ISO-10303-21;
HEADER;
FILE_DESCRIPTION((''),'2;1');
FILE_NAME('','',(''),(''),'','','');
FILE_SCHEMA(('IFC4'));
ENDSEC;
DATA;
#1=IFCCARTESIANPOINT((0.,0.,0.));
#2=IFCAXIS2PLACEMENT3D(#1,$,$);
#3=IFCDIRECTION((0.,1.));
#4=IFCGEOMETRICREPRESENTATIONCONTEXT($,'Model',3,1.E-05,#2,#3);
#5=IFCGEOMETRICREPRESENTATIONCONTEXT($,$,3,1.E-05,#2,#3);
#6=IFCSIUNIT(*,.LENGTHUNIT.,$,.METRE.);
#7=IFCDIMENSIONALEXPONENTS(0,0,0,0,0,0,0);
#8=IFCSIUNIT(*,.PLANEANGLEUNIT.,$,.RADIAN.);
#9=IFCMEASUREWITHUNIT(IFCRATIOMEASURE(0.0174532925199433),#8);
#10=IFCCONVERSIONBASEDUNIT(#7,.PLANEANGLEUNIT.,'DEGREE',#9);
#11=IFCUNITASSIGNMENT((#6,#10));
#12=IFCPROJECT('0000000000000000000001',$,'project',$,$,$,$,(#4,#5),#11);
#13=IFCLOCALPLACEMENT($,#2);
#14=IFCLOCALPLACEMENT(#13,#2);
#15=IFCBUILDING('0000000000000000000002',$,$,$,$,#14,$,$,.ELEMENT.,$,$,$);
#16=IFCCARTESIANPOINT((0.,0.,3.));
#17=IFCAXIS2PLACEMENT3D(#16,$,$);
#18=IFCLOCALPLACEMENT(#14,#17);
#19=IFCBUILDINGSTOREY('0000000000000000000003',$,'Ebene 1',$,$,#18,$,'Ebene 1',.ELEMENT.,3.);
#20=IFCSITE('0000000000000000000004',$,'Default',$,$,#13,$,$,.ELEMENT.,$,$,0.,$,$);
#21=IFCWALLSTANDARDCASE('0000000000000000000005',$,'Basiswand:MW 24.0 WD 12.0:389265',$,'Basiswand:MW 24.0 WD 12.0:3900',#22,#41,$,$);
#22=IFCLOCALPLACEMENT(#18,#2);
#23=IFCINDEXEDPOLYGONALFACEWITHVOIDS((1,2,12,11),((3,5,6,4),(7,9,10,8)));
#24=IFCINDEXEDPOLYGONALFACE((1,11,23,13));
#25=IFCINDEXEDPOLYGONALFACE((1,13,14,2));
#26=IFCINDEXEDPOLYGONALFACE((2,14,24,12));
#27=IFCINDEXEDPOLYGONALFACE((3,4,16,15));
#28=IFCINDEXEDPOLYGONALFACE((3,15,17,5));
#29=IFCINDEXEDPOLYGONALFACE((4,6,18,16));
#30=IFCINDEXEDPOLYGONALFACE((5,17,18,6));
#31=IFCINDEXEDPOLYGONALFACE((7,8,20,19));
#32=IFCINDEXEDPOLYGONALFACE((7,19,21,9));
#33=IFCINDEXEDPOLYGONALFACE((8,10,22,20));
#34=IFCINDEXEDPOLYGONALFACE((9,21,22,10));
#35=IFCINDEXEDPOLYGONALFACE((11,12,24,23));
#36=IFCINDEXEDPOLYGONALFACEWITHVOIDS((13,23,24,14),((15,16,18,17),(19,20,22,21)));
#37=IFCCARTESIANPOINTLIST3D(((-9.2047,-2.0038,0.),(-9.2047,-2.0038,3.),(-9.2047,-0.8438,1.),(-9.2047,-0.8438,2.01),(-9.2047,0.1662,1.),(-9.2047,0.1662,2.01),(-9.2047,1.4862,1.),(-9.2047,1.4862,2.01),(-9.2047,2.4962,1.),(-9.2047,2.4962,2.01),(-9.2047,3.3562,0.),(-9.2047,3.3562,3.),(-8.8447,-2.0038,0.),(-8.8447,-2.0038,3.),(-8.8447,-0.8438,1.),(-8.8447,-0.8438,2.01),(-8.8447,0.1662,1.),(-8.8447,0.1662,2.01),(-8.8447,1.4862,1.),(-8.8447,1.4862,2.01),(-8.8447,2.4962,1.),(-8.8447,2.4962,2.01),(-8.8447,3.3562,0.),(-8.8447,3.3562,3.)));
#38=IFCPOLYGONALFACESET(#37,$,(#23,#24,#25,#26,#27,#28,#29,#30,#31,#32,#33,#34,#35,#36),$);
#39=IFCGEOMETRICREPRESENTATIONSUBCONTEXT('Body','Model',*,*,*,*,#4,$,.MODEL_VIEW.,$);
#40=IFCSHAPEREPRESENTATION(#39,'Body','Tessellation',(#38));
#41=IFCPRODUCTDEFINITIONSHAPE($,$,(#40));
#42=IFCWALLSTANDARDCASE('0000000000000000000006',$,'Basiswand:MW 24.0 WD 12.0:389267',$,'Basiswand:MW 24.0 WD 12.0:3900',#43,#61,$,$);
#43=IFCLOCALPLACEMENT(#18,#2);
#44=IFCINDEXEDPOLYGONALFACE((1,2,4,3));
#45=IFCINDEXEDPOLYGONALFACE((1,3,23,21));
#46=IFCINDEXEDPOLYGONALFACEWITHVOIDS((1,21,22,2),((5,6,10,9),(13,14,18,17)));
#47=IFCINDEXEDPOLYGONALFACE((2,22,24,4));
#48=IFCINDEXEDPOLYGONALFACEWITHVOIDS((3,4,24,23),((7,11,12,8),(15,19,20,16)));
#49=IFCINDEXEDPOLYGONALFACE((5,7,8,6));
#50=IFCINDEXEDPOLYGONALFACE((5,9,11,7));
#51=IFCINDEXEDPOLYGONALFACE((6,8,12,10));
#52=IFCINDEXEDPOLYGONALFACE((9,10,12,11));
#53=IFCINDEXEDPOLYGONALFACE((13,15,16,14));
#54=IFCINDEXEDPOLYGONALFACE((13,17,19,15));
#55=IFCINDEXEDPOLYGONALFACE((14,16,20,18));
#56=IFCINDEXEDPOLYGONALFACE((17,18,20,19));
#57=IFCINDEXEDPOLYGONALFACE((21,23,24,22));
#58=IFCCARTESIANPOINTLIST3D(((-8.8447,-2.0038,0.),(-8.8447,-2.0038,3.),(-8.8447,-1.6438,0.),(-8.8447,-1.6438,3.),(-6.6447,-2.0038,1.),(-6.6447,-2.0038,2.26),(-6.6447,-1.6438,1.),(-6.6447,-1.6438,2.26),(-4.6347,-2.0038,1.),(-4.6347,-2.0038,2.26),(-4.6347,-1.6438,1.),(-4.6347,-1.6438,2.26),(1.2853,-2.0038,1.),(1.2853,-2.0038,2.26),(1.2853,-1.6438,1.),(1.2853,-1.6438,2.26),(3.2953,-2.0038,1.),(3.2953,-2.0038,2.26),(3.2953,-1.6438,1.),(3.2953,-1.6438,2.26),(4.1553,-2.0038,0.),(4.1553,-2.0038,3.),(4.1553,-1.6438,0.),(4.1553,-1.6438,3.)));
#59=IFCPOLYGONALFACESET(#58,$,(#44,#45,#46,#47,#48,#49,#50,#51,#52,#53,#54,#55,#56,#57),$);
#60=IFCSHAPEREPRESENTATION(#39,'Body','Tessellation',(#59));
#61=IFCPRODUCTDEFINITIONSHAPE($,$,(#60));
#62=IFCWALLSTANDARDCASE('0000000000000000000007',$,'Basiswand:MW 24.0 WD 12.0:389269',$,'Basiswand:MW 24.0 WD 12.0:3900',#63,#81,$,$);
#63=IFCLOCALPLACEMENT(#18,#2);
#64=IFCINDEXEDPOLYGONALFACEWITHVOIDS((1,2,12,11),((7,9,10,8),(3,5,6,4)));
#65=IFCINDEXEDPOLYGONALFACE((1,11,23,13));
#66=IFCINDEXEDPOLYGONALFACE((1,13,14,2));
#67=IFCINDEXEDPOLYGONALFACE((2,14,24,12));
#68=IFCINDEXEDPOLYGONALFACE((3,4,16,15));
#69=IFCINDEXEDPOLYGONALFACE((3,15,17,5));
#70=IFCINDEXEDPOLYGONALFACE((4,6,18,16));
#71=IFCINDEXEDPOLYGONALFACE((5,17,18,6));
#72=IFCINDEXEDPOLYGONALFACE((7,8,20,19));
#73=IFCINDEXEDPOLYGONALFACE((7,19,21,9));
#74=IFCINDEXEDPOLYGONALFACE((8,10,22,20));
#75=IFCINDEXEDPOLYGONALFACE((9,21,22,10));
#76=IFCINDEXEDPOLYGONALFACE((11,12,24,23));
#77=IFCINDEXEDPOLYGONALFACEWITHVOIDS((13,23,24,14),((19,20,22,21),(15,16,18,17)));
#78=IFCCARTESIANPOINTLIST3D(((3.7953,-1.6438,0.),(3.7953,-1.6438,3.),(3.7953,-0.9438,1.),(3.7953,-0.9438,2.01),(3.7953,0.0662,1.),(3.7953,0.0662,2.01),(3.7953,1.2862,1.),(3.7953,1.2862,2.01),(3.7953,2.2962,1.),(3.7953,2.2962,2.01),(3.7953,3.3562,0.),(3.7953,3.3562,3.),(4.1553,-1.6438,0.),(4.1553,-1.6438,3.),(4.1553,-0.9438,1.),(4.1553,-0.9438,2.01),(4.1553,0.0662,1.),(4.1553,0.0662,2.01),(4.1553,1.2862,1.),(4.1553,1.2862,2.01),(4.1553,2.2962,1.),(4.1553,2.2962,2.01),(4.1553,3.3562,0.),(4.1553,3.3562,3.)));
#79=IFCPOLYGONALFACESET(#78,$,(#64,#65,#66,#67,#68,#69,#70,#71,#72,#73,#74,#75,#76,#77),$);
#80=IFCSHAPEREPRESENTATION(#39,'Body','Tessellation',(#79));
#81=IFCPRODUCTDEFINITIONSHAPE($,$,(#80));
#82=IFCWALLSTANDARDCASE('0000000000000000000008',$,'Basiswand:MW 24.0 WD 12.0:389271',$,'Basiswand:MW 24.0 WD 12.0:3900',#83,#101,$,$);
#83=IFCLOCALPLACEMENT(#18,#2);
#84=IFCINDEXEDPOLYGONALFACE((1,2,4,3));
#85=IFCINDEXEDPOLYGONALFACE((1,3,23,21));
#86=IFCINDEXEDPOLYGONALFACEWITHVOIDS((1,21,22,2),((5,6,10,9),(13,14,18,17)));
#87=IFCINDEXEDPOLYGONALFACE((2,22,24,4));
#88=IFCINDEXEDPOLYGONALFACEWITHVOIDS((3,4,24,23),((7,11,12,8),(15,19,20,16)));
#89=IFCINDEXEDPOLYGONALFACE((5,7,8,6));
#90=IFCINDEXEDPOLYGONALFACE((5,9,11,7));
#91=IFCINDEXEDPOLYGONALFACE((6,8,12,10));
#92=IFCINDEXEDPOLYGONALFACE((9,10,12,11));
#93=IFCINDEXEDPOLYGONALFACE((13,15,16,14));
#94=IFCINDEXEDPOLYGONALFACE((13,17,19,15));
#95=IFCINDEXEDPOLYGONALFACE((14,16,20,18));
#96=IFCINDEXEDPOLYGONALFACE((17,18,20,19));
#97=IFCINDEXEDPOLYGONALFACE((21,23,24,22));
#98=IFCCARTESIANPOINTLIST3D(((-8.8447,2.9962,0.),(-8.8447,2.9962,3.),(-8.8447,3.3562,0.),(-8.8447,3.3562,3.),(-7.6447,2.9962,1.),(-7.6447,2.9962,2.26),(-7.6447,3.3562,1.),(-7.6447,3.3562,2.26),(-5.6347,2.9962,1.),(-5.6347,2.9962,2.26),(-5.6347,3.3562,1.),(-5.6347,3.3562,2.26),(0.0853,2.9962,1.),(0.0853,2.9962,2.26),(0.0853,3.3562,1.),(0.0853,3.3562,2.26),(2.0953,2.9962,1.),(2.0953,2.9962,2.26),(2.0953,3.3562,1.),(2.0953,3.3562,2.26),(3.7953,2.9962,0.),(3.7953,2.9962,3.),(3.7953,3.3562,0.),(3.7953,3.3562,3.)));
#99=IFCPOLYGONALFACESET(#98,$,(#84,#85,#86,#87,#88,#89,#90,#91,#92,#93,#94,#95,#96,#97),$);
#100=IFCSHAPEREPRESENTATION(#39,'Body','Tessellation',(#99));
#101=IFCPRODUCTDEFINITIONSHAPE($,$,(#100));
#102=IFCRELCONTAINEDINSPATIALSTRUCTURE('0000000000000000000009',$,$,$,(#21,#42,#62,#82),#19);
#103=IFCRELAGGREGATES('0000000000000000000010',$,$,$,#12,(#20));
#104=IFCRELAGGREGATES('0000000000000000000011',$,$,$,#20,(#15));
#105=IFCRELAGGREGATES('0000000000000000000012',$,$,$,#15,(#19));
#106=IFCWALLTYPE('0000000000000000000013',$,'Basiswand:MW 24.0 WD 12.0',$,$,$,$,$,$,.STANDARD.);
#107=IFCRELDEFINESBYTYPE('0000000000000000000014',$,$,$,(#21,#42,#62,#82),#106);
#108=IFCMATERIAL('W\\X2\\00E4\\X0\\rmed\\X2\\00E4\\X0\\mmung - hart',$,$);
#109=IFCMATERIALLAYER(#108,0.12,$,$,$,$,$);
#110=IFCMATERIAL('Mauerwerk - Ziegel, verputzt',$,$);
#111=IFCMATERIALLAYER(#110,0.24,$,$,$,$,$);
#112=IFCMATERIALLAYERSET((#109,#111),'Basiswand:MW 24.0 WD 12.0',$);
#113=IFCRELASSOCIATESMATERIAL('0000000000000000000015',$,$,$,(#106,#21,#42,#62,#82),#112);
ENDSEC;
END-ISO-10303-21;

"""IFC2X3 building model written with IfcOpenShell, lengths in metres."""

from ifc_helpers import new_model, entity, si_unit, converted_unit, direction, frame, frame_2d, origin, place, context, subcontext, project, spatial, rectangle, extrude, material, layer, layer_set, layer_usage, type_object, element, save


model = new_model("IFC2X3")

# Units and contexts
model_context = context("Model", 3, precision=1e-05, world=origin(), true_north=direction((0.0, 1.0)))
context_of_model = context(None, 3, precision=1e-05, world=origin(), true_north=direction((0.0, 1.0)))
body_context = subcontext(model_context, "Body", "Model", "MODEL_VIEW")
ifc_project = project(units=[si_unit("LENGTHUNIT", "METRE"), converted_unit("PLANEANGLEUNIT", "DEGREE", entity("IfcRatioMeasure", 0.0174532925199433), si_unit("PLANEANGLEUNIT", "RADIAN"), dimensions=[0, 0, 0, 0, 0, 0, 0])], contexts=[model_context, context_of_model])

# Site, building, storey
site_placement = place(None, origin())
site = spatial("IfcSite", under=ifc_project, at=site_placement, Name="Default", CompositionType="ELEMENT", RefElevation=0.0)
building_placement = place(site_placement, origin())
building = spatial("IfcBuilding", under=site, at=building_placement, CompositionType="ELEMENT")
storey_placement = place(building_placement, frame((0.0, 0.0, 3.0)))
storey = spatial("IfcBuildingStorey", under=building, at=storey_placement, Name="Ebene 1", LongName="Ebene 1", CompositionType="ELEMENT", Elevation=3.0)

# Walls, openings
ifc_material_1 = material(Name="W\\X2\\00E4\\X0\\rmed\\X2\\00E4\\X0\\mmung - hart")
ifc_layer_1 = layer(ifc_material_1, 0.12)
ifc_material_2 = material(Name="Mauerwerk - Ziegel, verputzt")
ifc_layer_2 = layer(ifc_material_2, 0.24)
ifc_layer_set = layer_set([ifc_layer_1, ifc_layer_2], Name="Basiswand:MW 24.0 WD 12.0")
ifc_layer_usage = layer_usage(ifc_layer_set, "AXIS2", "NEGATIVE", 0.18)
wall_type = type_object("IfcWallType", Name="Basiswand:MW 24.0 WD 12.0", PredefinedType="STANDARD", material=ifc_layer_set)
wall_1_placement = place(storey_placement, frame((-9.0247, 3.3562, 0.0), z_axis=(0.0, 0.0, 1.0), x_axis=(0.0, -1.0, 0.0)))
wall_1 = element("IfcWallStandardCase", 1, at=wall_1_placement, inside=storey, type_object=wall_type, material=ifc_layer_usage, Name="Basiswand:MW 24.0 WD 12.0:389265", ObjectType="Basiswand:MW 24.0 WD 12.0:3900", context=body_context, shape_type="SweptSolid", body=[
    extrude(rectangle(XDim=5.36, YDim=0.36, at=frame_2d((2.68, 0.0), x_axis=(-1.0, 0.0))), origin(), (0.0, 0.0, 1.0), 3.0),
])
opening_1_placement = place(wall_1_placement, frame((1.87, 0.18, 1.0)))
element("IfcOpeningElement", 2, at=opening_1_placement, cuts=wall_1, ObjectType="Opening", context=body_context, shape_type="SweptSolid", body=[
    extrude(rectangle(XDim=1.01, YDim=1.01, at=frame_2d((0.505, 0.505), x_axis=(1.0, 0.0))), frame((0.0, 0.0, 0.0), z_axis=(0.0, -1.0, 0.0), x_axis=(0.0, 0.0, 1.0)), (0.0, 0.0, 1.0), 0.36),
])
opening_2_placement = place(wall_1_placement, frame((4.2, 0.18, 1.0)))
element("IfcOpeningElement", 3, at=opening_2_placement, cuts=wall_1, ObjectType="Opening", context=body_context, shape_type="SweptSolid", body=[
    extrude(rectangle(XDim=1.01, YDim=1.01, at=frame_2d((0.505, 0.505), x_axis=(1.0, 0.0))), frame((0.0, 0.0, 0.0), z_axis=(0.0, -1.0, 0.0), x_axis=(0.0, 0.0, 1.0)), (0.0, 0.0, 1.0), 0.36),
])
wall_2_placement = place(storey_placement, frame((-8.8447, -1.8238, 0.0)))
wall_2 = element("IfcWallStandardCase", 4, at=wall_2_placement, inside=storey, type_object=wall_type, material=ifc_layer_usage, Name="Basiswand:MW 24.0 WD 12.0:389267", ObjectType="Basiswand:MW 24.0 WD 12.0:3900", context=body_context, shape_type="SweptSolid", body=[
    extrude(rectangle(XDim=13.0, YDim=0.36, at=frame_2d((6.5, 0.0), x_axis=(-1.0, 0.0))), origin(), (0.0, 0.0, 1.0), 3.0),
])
opening_3_placement = place(wall_2_placement, frame((12.14, 0.18, 1.0)))
element("IfcOpeningElement", 5, at=opening_3_placement, cuts=wall_2, ObjectType="Opening", context=body_context, shape_type="SweptSolid", body=[
    extrude(rectangle(XDim=1.26, YDim=2.01, at=frame_2d((0.63, 1.005), x_axis=(1.0, 0.0))), frame((0.0, 0.0, 0.0), z_axis=(0.0, -1.0, 0.0), x_axis=(0.0, 0.0, 1.0)), (0.0, 0.0, 1.0), 0.36),
])
opening_4_placement = place(wall_2_placement, frame((4.21, 0.18, 1.0)))
element("IfcOpeningElement", 6, at=opening_4_placement, cuts=wall_2, ObjectType="Opening", context=body_context, shape_type="SweptSolid", body=[
    extrude(rectangle(XDim=1.26, YDim=2.01, at=frame_2d((0.63, 1.005), x_axis=(1.0, 0.0))), frame((0.0, 0.0, 0.0), z_axis=(0.0, -1.0, 0.0), x_axis=(0.0, 0.0, 1.0)), (0.0, 0.0, 1.0), 0.36),
])
wall_3_placement = place(storey_placement, frame((3.9753, -1.6438, 0.0), z_axis=(0.0, 0.0, 1.0), x_axis=(0.0, 1.0, 0.0)))
wall_3 = element("IfcWallStandardCase", 7, at=wall_3_placement, inside=storey, type_object=wall_type, material=ifc_layer_usage, Name="Basiswand:MW 24.0 WD 12.0:389269", ObjectType="Basiswand:MW 24.0 WD 12.0:3900", context=body_context, shape_type="SweptSolid", body=[
    extrude(rectangle(XDim=5.0, YDim=0.36, at=frame_2d((2.5, 0.0), x_axis=(-1.0, 0.0))), origin(), (0.0, 0.0, 1.0), 3.0),
])
opening_5_placement = place(wall_3_placement, frame((3.94, 0.18, 1.0)))
element("IfcOpeningElement", 8, at=opening_5_placement, cuts=wall_3, ObjectType="Opening", context=body_context, shape_type="SweptSolid", body=[
    extrude(rectangle(XDim=1.01, YDim=1.01, at=frame_2d((0.505, 0.505), x_axis=(1.0, 0.0))), frame((0.0, 0.0, 0.0), z_axis=(0.0, -1.0, 0.0), x_axis=(0.0, 0.0, 1.0)), (0.0, 0.0, 1.0), 0.36),
])
opening_6_placement = place(wall_3_placement, frame((1.71, 0.18, 1.0)))
element("IfcOpeningElement", 9, at=opening_6_placement, cuts=wall_3, ObjectType="Opening", context=body_context, shape_type="SweptSolid", body=[
    extrude(rectangle(XDim=1.01, YDim=1.01, at=frame_2d((0.505, 0.505), x_axis=(1.0, 0.0))), frame((0.0, 0.0, 0.0), z_axis=(0.0, -1.0, 0.0), x_axis=(0.0, 0.0, 1.0)), (0.0, 0.0, 1.0), 0.36),
])
wall_4_placement = place(storey_placement, frame((3.7953, 3.1762, 0.0), z_axis=(0.0, 0.0, 1.0), x_axis=(-1.0, 0.0, 0.0)))
wall_4 = element("IfcWallStandardCase", 10, at=wall_4_placement, inside=storey, type_object=wall_type, material=ifc_layer_usage, Name="Basiswand:MW 24.0 WD 12.0:389271", ObjectType="Basiswand:MW 24.0 WD 12.0:3900", context=body_context, shape_type="SweptSolid", body=[
    extrude(rectangle(XDim=12.64, YDim=0.36, at=frame_2d((6.32, 0.0), x_axis=(-1.0, 0.0))), origin(), (0.0, 0.0, 1.0), 3.0),
])
opening_7_placement = place(wall_4_placement, frame((3.71, 0.18, 1.0)))
element("IfcOpeningElement", 11, at=opening_7_placement, cuts=wall_4, ObjectType="Opening", context=body_context, shape_type="SweptSolid", body=[
    extrude(rectangle(XDim=1.26, YDim=2.01, at=frame_2d((0.63, 1.005), x_axis=(1.0, 0.0))), frame((0.0, 0.0, 0.0), z_axis=(0.0, -1.0, 0.0), x_axis=(0.0, 0.0, 1.0)), (0.0, 0.0, 1.0), 0.36),
])
opening_8_placement = place(wall_4_placement, frame((11.44, 0.18, 1.0)))
element("IfcOpeningElement", 12, at=opening_8_placement, cuts=wall_4, ObjectType="Opening", context=body_context, shape_type="SweptSolid", body=[
    extrude(rectangle(XDim=1.26, YDim=2.01, at=frame_2d((0.63, 1.005), x_axis=(1.0, 0.0))), frame((0.0, 0.0, 0.0), z_axis=(0.0, -1.0, 0.0), x_axis=(0.0, 0.0, 1.0)), (0.0, 0.0, 1.0), 0.36),
])

save(model, "model.ifc")
